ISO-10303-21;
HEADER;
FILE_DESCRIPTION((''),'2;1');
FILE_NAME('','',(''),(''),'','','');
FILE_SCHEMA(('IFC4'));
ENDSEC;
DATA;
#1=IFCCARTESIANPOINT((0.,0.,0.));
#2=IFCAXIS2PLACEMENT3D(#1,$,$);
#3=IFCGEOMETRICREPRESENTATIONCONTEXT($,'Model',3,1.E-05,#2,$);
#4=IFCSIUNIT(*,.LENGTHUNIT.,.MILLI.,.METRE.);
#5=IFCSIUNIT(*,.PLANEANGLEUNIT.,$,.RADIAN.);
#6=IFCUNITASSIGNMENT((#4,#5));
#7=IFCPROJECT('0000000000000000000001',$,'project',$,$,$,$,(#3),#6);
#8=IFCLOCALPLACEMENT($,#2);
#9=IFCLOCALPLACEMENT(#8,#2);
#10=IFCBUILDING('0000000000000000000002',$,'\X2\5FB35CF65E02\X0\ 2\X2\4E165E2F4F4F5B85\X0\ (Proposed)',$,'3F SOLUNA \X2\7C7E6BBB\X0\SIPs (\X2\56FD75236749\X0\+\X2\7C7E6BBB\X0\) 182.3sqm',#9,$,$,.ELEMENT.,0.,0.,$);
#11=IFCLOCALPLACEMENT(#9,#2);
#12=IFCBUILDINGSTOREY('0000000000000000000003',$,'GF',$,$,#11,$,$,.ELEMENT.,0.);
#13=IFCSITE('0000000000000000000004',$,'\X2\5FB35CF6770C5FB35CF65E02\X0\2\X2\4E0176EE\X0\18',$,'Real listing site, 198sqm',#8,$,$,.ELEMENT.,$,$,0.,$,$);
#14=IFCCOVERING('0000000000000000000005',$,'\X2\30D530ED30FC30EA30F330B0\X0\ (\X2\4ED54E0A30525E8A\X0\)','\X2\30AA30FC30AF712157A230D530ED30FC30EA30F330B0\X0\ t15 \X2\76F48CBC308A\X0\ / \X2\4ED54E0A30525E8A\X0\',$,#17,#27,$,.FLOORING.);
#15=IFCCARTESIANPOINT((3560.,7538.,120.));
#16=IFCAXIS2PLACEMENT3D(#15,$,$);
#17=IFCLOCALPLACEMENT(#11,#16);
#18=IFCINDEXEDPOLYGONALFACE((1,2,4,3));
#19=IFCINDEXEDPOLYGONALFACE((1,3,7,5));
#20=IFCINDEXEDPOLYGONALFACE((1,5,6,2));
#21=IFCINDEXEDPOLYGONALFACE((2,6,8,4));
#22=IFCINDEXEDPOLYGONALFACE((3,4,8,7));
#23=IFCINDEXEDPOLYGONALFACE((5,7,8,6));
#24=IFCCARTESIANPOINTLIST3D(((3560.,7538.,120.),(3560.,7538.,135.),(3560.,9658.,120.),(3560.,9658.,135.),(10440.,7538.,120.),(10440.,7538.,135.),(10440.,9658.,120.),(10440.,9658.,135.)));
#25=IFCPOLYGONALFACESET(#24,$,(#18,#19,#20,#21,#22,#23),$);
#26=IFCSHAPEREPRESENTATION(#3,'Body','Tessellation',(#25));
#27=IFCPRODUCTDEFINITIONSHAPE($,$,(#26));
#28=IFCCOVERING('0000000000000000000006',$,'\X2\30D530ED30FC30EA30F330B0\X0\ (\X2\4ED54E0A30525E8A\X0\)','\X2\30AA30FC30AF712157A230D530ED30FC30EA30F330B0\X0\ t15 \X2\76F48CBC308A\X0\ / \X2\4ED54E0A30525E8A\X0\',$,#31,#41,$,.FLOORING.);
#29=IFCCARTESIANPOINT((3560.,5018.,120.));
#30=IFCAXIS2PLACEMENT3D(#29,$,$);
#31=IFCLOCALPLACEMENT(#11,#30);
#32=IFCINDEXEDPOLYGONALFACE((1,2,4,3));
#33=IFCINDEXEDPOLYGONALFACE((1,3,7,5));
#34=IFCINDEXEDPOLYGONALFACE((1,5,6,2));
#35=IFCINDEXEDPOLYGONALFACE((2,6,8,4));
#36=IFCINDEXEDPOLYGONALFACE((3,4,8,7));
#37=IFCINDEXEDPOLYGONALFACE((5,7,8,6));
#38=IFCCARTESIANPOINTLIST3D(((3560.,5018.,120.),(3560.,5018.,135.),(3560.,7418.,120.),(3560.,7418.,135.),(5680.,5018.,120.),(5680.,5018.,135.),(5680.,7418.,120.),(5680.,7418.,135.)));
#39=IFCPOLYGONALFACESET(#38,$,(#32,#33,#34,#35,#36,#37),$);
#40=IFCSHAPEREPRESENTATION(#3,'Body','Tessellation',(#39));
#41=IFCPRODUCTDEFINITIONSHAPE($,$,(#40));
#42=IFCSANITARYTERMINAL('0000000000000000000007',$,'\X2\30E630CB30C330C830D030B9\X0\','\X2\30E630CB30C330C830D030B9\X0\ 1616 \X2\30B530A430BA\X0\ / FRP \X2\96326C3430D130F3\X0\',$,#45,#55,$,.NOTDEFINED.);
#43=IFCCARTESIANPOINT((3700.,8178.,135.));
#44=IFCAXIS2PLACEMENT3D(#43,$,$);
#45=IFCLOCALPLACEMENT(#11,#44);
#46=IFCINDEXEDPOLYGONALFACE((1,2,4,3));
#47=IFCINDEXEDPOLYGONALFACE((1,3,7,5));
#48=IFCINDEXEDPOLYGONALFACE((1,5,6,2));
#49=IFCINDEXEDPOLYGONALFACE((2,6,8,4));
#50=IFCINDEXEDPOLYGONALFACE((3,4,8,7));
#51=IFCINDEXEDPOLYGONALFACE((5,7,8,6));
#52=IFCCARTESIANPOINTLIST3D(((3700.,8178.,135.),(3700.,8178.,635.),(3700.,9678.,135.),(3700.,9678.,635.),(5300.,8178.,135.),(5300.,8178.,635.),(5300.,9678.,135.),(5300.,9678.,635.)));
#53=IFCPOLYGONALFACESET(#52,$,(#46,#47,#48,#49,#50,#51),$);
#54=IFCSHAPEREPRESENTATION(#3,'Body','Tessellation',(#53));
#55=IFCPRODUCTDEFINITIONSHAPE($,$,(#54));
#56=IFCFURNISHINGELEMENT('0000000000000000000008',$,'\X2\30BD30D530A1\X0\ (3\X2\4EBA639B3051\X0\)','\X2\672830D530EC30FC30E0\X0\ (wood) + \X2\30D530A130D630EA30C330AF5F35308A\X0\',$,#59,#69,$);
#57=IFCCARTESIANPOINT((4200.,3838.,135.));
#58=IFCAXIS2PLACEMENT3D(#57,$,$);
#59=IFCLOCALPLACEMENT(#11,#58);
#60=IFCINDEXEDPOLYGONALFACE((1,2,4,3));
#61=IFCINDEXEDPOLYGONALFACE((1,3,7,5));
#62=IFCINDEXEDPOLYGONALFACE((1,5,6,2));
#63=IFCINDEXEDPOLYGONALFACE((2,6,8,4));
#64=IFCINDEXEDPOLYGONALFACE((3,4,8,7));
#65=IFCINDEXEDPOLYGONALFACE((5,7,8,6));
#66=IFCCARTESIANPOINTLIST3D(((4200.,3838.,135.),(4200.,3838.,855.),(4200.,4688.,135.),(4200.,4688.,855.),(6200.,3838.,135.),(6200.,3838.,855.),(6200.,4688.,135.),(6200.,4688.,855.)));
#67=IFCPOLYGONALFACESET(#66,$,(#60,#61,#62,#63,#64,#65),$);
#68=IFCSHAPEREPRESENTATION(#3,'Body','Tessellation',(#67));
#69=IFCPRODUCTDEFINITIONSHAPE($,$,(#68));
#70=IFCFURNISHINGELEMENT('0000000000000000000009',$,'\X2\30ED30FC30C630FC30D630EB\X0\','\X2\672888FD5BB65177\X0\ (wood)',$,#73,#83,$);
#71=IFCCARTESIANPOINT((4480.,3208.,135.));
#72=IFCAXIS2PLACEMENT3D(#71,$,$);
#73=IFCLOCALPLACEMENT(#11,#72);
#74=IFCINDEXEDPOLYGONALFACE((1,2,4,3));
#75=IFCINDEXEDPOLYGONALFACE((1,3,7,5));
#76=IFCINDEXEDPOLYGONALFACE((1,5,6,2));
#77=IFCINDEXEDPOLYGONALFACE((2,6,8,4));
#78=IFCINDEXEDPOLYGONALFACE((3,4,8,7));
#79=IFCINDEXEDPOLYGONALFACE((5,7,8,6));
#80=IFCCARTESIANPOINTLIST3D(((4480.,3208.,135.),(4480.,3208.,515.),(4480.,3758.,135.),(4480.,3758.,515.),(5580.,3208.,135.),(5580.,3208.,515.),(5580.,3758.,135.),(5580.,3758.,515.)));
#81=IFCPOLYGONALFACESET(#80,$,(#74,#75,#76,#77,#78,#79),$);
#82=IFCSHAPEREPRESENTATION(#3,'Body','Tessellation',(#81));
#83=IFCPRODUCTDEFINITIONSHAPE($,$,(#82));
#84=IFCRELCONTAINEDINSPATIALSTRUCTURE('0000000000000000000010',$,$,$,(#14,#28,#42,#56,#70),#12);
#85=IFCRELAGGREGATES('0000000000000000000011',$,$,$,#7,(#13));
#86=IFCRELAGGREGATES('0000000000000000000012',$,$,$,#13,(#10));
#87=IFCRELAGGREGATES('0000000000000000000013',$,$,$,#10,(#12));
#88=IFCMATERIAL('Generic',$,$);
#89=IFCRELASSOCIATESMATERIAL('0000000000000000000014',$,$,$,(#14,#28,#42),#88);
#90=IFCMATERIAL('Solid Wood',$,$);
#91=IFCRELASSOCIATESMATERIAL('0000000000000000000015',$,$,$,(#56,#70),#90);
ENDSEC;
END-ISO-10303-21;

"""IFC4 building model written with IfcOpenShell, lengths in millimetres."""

from ifc_helpers import new_model, si_unit, frame, frame_2d, origin, place, context, project, spatial, rectangle, extrude, material, element, save


model = new_model("IFC4")

# Units and contexts
model_context = context("Model", 3, precision=1e-05, world=origin())
ifc_project = project(units=[si_unit("LENGTHUNIT", "METRE", prefix="MILLI"), si_unit("PLANEANGLEUNIT", "RADIAN")], contexts=[model_context])

# Site, building, storey
site_placement = place(None, origin())
site = spatial("IfcSite", under=ifc_project, at=site_placement, Name="徳島県徳島市2丁目18", ObjectType="Real listing site, 198sqm", CompositionType="ELEMENT", RefElevation=0.0)
building_placement = place(site_placement, origin())
building = spatial("IfcBuilding", under=site, at=building_placement, Name="徳島市 2世帯住宅 (Proposed)", ObjectType="3F SOLUNA 籾殻SIPs (国産杉+籾殻) 182.3sqm", CompositionType="ELEMENT", ElevationOfRefHeight=0.0, ElevationOfTerrain=0.0)
storey_placement = place(building_placement, origin())
storey = spatial("IfcBuildingStorey", under=building, at=storey_placement, Name="GF", CompositionType="ELEMENT", Elevation=0.0)

# Shared definitions
ifc_material_1 = material(Name="Solid Wood")

# Coverings
ifc_material_2 = material(Name="Generic")
covering_1_placement = place(storey_placement, frame((3560.0, 7538.0, 120.0)))
element("IfcCovering", 1, at=covering_1_placement, inside=storey, material=ifc_material_2, Name="フローリング (仕上げ床)", Description="オーク無垢フローリング t15 直貼り / 仕上げ床", PredefinedType="FLOORING", context=model_context, shape_type="SweptSolid", body=[
    extrude(rectangle(XDim=6880.0, YDim=2120.0, at=frame_2d((3440.0, 1060.0))), frame((3560.0, 7538.0, 120.0)), (0.0, 0.0, 1.0), 15.0),
])
covering_2_placement = place(storey_placement, frame((3560.0, 5018.0, 120.0)))
element("IfcCovering", 2, at=covering_2_placement, inside=storey, material=ifc_material_2, Name="フローリング (仕上げ床)", Description="オーク無垢フローリング t15 直貼り / 仕上げ床", PredefinedType="FLOORING", context=model_context, shape_type="SweptSolid", body=[
    extrude(rectangle(XDim=2120.0, YDim=2400.0, at=frame_2d((1060.0, 1200.0))), frame((3560.0, 5018.0, 120.0)), (0.0, 0.0, 1.0), 15.0),
])

# Sanitary terminal
sanitary_terminal_placement = place(storey_placement, frame((3700.0, 8178.0, 135.0)))
element("IfcSanitaryTerminal", 3, at=sanitary_terminal_placement, inside=storey, material=ifc_material_2, Name="ユニットバス", Description="ユニットバス 1616 サイズ / FRP 防水パン", PredefinedType="NOTDEFINED", context=model_context, shape_type="SweptSolid", body=[
    extrude(rectangle(XDim=1600.0, YDim=1500.0, at=frame_2d((800.0, 750.0))), frame((3700.0, 8178.0, 135.0)), (0.0, 0.0, 1.0), 500.0),
])

# Furnishing elements
furnishing_1_placement = place(storey_placement, frame((4200.0, 3838.0, 135.0)))
element("IfcFurnishingElement", 4, at=furnishing_1_placement, inside=storey, material=ifc_material_1, Name="ソファ (3人掛け)", Description="木フレーム (wood) + ファブリック張り", context=model_context, shape_type="SweptSolid", body=[
    extrude(rectangle(XDim=2000.0, YDim=850.0, at=frame_2d((1000.0, 425.0))), frame((4200.0, 3838.0, 135.0)), (0.0, 0.0, 1.0), 720.0),
])
furnishing_2_placement = place(storey_placement, frame((4480.0, 3208.0, 135.0)))
element("IfcFurnishingElement", 5, at=furnishing_2_placement, inside=storey, material=ifc_material_1, Name="ローテーブル", Description="木製家具 (wood)", context=model_context, shape_type="SweptSolid", body=[
    extrude(rectangle(XDim=1100.0, YDim=550.0, at=frame_2d((550.0, 275.0))), frame((4480.0, 3208.0, 135.0)), (0.0, 0.0, 1.0), 380.0),
])

save(model, "model.ifc")
